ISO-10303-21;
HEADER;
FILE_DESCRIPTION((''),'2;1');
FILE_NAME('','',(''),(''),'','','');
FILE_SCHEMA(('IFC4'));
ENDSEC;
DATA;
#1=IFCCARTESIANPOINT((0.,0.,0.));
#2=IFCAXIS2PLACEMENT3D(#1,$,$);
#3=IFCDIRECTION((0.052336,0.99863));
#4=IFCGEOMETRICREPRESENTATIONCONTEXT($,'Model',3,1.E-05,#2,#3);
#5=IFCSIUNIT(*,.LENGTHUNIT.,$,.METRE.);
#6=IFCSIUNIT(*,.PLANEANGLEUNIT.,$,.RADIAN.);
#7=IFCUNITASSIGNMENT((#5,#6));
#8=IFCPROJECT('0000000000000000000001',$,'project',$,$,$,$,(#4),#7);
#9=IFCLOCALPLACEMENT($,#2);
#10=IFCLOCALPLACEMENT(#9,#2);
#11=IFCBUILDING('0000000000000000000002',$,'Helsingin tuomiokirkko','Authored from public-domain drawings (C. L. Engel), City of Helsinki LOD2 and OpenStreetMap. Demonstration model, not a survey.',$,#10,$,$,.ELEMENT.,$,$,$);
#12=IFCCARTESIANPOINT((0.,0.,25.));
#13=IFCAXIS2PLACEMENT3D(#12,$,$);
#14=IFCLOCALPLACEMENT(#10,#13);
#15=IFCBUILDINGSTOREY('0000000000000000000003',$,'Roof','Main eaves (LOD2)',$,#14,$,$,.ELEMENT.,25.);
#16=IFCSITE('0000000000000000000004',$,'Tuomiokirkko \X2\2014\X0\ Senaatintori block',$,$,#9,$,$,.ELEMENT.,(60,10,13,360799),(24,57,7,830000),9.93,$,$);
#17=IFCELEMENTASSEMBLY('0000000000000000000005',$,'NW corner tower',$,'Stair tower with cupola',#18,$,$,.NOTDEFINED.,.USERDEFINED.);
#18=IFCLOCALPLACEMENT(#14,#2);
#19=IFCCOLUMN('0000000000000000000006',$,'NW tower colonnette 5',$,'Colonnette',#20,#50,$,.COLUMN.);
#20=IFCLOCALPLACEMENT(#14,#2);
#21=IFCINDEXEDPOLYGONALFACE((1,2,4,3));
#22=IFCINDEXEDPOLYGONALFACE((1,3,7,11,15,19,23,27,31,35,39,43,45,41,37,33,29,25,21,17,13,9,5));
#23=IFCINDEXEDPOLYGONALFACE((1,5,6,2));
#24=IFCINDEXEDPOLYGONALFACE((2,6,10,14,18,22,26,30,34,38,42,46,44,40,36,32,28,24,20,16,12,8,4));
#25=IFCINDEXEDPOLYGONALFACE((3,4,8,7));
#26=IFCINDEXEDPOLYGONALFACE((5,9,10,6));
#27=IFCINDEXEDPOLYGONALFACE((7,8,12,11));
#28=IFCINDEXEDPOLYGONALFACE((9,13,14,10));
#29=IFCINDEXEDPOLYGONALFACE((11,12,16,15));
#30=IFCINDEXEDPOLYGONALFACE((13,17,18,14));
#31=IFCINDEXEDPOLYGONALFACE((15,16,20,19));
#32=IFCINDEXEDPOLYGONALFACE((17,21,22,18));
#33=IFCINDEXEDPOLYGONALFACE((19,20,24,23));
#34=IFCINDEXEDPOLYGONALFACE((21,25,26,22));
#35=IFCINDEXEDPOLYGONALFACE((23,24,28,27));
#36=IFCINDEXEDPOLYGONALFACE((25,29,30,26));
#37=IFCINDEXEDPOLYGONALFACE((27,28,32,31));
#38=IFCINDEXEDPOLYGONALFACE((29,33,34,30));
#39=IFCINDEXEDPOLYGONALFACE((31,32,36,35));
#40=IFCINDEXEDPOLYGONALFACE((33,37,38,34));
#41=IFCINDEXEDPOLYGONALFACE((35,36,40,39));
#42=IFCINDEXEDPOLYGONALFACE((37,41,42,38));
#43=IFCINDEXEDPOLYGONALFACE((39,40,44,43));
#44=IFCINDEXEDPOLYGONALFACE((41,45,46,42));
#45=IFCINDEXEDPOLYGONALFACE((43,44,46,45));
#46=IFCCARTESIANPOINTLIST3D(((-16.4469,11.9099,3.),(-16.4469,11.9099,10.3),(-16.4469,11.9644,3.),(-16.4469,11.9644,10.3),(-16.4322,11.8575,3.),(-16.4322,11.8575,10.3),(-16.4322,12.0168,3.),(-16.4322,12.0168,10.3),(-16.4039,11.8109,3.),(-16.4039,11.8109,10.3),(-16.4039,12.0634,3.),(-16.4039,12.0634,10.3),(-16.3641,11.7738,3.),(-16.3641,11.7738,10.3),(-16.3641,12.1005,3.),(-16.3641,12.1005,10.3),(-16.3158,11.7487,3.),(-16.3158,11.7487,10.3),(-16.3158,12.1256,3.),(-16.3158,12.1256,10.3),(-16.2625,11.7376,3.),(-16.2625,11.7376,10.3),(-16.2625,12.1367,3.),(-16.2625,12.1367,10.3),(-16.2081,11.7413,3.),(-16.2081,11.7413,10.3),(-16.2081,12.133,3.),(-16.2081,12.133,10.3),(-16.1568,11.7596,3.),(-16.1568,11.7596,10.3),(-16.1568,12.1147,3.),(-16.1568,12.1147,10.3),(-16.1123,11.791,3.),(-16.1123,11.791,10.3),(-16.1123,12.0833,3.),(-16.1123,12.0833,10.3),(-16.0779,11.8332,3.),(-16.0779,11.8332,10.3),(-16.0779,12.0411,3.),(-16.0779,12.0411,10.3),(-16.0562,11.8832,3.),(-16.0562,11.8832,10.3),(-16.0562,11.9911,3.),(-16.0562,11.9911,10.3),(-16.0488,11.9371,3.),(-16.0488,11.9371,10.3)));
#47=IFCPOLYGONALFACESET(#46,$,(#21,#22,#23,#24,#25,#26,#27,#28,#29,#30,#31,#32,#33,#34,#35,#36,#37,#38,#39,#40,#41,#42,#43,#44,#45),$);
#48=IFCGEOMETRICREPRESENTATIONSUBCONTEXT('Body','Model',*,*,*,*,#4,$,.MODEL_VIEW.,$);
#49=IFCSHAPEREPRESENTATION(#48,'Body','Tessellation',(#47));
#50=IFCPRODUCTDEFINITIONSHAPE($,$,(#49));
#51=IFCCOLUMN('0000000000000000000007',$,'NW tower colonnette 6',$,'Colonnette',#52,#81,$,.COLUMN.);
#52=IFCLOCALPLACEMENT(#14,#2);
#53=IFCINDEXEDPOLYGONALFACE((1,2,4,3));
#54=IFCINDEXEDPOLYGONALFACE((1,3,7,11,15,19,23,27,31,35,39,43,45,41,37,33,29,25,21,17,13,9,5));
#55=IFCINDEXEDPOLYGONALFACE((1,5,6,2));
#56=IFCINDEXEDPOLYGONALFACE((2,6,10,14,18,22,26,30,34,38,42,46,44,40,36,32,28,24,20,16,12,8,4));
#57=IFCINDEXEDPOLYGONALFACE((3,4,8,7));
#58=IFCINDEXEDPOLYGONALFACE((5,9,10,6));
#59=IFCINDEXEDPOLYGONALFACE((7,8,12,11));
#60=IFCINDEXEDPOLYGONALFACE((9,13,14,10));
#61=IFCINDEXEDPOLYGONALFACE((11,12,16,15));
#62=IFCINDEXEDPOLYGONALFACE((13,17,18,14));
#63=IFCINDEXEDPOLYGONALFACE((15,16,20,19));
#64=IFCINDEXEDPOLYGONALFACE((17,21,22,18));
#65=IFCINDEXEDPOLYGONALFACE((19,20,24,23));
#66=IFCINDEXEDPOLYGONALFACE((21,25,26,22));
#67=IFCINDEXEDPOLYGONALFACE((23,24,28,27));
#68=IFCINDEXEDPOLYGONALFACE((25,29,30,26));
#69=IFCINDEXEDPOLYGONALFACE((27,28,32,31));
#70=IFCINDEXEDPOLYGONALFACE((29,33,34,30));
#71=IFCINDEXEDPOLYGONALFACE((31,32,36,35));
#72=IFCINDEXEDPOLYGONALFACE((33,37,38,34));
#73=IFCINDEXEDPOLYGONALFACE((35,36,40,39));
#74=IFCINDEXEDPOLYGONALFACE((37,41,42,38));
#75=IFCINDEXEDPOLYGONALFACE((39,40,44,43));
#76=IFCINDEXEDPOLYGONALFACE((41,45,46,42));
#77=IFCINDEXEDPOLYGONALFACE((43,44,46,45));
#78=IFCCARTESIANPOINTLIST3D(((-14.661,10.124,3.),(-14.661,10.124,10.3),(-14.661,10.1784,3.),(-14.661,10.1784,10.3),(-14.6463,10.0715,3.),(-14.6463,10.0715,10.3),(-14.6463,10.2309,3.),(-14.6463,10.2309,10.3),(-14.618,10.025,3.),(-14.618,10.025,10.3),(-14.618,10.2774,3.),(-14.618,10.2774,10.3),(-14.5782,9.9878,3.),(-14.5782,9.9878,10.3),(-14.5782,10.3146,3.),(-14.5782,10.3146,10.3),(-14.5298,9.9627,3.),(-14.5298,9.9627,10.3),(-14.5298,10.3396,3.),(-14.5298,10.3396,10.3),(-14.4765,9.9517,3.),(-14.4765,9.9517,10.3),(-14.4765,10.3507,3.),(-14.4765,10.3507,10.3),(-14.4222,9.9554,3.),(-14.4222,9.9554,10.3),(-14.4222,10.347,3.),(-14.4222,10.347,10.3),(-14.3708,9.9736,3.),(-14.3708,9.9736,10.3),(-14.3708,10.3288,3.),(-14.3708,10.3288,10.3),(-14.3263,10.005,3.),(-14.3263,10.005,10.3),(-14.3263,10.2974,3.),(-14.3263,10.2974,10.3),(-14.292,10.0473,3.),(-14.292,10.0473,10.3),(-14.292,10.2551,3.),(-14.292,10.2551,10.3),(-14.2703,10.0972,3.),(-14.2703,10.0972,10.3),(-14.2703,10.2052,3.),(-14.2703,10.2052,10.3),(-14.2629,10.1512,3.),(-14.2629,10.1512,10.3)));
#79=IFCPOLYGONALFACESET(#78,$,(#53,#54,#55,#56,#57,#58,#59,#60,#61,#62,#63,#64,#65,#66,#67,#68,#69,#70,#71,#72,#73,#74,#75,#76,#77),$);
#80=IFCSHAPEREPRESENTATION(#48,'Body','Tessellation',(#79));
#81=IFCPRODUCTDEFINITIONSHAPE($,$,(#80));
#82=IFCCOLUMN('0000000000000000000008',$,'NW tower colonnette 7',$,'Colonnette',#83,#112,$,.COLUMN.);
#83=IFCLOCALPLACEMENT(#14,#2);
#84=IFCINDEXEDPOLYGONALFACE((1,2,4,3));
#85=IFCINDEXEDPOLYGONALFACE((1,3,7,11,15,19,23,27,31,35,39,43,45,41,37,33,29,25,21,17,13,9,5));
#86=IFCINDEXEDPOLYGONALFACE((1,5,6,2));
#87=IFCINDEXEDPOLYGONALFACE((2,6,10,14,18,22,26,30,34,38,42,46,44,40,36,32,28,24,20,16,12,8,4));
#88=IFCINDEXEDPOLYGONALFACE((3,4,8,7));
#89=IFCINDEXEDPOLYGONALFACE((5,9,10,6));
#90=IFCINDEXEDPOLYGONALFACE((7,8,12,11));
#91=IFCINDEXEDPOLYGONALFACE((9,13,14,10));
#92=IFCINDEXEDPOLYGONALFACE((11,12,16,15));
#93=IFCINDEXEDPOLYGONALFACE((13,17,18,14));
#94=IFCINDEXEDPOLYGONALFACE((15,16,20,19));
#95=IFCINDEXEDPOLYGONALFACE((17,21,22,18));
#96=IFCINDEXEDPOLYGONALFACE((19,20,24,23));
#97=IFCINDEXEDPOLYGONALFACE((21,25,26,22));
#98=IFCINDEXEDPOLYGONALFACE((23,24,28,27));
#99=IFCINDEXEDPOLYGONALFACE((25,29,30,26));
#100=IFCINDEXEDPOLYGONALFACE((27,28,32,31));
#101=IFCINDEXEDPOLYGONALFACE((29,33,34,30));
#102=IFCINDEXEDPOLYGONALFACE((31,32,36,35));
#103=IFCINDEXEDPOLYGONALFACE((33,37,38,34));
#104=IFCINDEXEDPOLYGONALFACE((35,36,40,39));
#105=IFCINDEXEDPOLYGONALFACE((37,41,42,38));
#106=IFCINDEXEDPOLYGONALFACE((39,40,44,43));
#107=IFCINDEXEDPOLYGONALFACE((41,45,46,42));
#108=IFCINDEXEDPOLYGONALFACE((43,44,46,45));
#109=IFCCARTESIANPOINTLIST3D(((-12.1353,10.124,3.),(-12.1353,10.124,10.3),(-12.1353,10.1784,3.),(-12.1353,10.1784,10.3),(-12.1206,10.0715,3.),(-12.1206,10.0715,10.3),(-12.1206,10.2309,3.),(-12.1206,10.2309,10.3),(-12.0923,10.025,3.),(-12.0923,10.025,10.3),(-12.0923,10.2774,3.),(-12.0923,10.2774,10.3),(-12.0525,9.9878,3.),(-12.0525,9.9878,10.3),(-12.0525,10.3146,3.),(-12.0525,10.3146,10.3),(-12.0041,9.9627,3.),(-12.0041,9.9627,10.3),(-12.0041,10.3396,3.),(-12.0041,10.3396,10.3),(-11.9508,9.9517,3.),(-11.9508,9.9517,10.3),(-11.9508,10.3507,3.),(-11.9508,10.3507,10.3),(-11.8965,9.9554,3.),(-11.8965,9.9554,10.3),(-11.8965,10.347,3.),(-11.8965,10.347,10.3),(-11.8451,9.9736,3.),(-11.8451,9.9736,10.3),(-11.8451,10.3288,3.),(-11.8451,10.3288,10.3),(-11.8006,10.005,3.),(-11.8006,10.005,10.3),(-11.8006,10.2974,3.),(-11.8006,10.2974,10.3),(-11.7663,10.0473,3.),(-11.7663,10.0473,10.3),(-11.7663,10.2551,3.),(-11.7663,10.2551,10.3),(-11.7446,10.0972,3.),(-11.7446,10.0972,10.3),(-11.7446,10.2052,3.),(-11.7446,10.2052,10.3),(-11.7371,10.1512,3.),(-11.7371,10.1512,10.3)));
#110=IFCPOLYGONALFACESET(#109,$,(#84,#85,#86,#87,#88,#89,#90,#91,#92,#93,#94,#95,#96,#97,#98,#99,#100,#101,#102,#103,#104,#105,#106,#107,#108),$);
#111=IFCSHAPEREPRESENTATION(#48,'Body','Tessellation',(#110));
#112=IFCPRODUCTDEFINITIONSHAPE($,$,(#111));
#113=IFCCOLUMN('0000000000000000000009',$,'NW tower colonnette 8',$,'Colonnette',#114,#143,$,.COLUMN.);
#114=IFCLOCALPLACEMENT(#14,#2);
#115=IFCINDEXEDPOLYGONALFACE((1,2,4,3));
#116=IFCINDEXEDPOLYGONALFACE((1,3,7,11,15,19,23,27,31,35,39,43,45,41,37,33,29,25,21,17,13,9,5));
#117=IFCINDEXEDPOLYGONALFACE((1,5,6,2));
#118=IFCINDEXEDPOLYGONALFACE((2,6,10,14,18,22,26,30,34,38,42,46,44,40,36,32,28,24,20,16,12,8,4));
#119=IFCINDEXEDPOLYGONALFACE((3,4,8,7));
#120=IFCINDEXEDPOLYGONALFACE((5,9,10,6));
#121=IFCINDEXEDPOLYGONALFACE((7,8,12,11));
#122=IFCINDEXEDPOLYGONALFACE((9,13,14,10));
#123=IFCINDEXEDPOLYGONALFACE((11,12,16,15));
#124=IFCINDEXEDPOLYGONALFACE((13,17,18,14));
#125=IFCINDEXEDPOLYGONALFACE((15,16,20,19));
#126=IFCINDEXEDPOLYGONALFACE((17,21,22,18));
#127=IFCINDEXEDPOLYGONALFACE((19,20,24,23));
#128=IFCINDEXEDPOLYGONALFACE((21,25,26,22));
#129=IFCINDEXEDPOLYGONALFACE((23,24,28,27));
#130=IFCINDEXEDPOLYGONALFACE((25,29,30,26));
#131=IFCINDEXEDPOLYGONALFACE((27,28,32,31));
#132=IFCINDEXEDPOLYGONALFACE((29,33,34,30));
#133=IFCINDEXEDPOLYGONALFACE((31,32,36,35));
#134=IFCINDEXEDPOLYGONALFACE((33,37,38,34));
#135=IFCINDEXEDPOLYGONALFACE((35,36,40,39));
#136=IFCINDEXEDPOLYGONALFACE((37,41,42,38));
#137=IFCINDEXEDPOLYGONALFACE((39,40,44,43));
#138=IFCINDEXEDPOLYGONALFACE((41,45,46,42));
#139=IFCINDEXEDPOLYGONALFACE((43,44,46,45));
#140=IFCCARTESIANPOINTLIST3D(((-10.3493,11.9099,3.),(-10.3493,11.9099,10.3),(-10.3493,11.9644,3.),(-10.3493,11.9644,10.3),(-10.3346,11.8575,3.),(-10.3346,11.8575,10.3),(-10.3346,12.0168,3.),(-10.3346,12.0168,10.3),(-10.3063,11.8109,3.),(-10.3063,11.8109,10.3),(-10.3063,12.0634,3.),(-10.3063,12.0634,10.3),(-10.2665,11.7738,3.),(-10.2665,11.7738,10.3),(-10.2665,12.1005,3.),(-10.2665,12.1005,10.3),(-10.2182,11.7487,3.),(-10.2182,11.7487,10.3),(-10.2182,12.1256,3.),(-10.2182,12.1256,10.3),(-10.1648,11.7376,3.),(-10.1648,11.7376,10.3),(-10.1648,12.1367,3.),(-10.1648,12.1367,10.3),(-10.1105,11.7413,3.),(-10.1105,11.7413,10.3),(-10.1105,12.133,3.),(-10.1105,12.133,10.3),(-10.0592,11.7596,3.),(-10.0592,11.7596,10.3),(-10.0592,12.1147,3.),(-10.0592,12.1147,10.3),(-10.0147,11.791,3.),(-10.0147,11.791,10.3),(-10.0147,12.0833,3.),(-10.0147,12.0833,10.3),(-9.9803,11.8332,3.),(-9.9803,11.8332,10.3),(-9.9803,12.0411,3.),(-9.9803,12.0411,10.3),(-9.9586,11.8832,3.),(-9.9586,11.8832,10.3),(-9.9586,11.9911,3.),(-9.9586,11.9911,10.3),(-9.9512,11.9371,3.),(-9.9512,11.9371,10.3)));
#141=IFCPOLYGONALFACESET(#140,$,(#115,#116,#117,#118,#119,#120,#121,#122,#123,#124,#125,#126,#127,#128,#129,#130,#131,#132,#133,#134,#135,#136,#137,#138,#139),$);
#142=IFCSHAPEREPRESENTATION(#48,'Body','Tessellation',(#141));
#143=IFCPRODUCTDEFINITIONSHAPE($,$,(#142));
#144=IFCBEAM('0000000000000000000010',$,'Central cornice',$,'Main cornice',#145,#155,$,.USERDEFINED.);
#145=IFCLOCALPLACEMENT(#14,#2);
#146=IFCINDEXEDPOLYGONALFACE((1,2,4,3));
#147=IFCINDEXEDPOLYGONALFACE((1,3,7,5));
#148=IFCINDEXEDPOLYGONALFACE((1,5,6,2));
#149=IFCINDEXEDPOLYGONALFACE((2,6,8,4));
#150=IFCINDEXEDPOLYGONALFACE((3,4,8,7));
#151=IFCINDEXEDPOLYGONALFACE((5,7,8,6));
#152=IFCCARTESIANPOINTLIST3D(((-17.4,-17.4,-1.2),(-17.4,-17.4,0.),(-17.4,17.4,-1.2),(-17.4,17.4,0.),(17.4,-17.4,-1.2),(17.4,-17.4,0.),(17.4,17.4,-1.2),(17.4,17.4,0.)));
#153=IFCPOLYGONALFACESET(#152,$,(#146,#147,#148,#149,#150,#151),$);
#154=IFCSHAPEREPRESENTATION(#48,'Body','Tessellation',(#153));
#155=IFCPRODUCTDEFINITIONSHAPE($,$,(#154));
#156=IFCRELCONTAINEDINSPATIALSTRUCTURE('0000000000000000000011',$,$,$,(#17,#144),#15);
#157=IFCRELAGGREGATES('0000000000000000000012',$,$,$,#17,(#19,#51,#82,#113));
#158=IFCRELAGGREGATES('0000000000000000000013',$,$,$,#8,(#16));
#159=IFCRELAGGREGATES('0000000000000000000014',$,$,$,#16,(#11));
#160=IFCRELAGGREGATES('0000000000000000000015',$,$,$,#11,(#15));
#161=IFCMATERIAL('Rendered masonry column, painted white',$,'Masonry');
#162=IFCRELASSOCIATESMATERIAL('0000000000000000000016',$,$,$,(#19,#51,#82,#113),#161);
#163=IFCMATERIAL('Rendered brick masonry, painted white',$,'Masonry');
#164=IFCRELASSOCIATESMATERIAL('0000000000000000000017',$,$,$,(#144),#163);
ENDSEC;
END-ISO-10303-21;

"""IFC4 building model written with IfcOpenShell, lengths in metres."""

from ifc_helpers import new_model, si_unit, direction, frame, origin, origin_2d_with_axis, place, context, subcontext, project, spatial, rectangle, circle, extrude, material, element, aggregate, save


model = new_model("IFC4")

# Units and contexts
model_context = context("Model", 3, precision=1e-05, world=origin(), true_north=direction((0.052336, 0.99863)))
body_context = subcontext(model_context, "Body", "Model", "MODEL_VIEW")
ifc_project = project(units=[si_unit("LENGTHUNIT", "METRE"), si_unit("PLANEANGLEUNIT", "RADIAN")], contexts=[model_context])

# Site, building, storey
site_placement = place(None, origin())
site = spatial("IfcSite", under=ifc_project, at=site_placement, Name="Tuomiokirkko — Senaatintori block", CompositionType="ELEMENT", RefLatitude=(60, 10, 13, 360799), RefLongitude=(24, 57, 7, 830000), RefElevation=9.93)
building_placement = place(site_placement, origin())
building = spatial("IfcBuilding", under=site, at=building_placement, Name="Helsingin tuomiokirkko", Description="Authored from public-domain drawings (C. L. Engel), City of Helsinki LOD2 and OpenStreetMap. Demonstration model, not a survey.", CompositionType="ELEMENT")
storey_placement = place(building_placement, frame((0.0, 0.0, 25.0)))
storey = spatial("IfcBuildingStorey", under=building, at=storey_placement, Name="Roof", Description="Main eaves (LOD2)", CompositionType="ELEMENT", Elevation=25.0)

# Element assembly, columns
ifc_material_1 = material(Name="Rendered masonry column, painted white", Category="Masonry")
assembly_1_placement = place(building_placement, origin())
assembly_1 = element("IfcElementAssembly", 1, at=assembly_1_placement, inside=storey, Name="NW corner tower", ObjectType="Stair tower with cupola", AssemblyPlace="NOTDEFINED", PredefinedType="USERDEFINED")
column_1_placement = place(building_placement, origin())
column_1 = element("IfcColumn", 2, at=column_1_placement, material=ifc_material_1, Name="NW tower colonnette 5", ObjectType="Colonnette", PredefinedType="COLUMN", context=body_context, shape_type="SweptSolid", body=[
    extrude(circle(Radius=0.2, at=origin_2d_with_axis()), frame((-16.2488, 11.9371, 28.0)), (0.0, 0.0, 1.0), 7.3),
])
column_2_placement = place(building_placement, origin())
column_2 = element("IfcColumn", 3, at=column_2_placement, material=ifc_material_1, Name="NW tower colonnette 6", ObjectType="Colonnette", PredefinedType="COLUMN", context=body_context, shape_type="SweptSolid", body=[
    extrude(circle(Radius=0.2, at=origin_2d_with_axis()), frame((-14.4629, 10.1512, 28.0)), (0.0, 0.0, 1.0), 7.3),
])
column_3_placement = place(building_placement, origin())
column_3 = element("IfcColumn", 4, at=column_3_placement, material=ifc_material_1, Name="NW tower colonnette 7", ObjectType="Colonnette", PredefinedType="COLUMN", context=body_context, shape_type="SweptSolid", body=[
    extrude(circle(Radius=0.2, at=origin_2d_with_axis()), frame((-11.9371, 10.1512, 28.0)), (0.0, 0.0, 1.0), 7.3),
])
column_4_placement = place(building_placement, origin())
column_4 = element("IfcColumn", 5, at=column_4_placement, material=ifc_material_1, Name="NW tower colonnette 8", ObjectType="Colonnette", PredefinedType="COLUMN", context=body_context, shape_type="SweptSolid", body=[
    extrude(circle(Radius=0.2, at=origin_2d_with_axis()), frame((-10.1512, 11.9371, 28.0)), (0.0, 0.0, 1.0), 7.3),
])

# Beam
ifc_material_2 = material(Name="Rendered brick masonry, painted white", Category="Masonry")
beam_1_placement = place(building_placement, origin())
element("IfcBeam", 6, at=beam_1_placement, inside=storey, material=ifc_material_2, Name="Central cornice", ObjectType="Main cornice", PredefinedType="USERDEFINED", context=body_context, shape_type="SweptSolid", body=[
    extrude(rectangle(XDim=34.8, YDim=34.8, at=origin_2d_with_axis()), frame((0.0, 0.0, 23.8)), (0.0, 0.0, 1.0), 1.2),
])

aggregate(assembly_1, [column_1, column_2, column_3, column_4])

save(model, "model.ifc")
